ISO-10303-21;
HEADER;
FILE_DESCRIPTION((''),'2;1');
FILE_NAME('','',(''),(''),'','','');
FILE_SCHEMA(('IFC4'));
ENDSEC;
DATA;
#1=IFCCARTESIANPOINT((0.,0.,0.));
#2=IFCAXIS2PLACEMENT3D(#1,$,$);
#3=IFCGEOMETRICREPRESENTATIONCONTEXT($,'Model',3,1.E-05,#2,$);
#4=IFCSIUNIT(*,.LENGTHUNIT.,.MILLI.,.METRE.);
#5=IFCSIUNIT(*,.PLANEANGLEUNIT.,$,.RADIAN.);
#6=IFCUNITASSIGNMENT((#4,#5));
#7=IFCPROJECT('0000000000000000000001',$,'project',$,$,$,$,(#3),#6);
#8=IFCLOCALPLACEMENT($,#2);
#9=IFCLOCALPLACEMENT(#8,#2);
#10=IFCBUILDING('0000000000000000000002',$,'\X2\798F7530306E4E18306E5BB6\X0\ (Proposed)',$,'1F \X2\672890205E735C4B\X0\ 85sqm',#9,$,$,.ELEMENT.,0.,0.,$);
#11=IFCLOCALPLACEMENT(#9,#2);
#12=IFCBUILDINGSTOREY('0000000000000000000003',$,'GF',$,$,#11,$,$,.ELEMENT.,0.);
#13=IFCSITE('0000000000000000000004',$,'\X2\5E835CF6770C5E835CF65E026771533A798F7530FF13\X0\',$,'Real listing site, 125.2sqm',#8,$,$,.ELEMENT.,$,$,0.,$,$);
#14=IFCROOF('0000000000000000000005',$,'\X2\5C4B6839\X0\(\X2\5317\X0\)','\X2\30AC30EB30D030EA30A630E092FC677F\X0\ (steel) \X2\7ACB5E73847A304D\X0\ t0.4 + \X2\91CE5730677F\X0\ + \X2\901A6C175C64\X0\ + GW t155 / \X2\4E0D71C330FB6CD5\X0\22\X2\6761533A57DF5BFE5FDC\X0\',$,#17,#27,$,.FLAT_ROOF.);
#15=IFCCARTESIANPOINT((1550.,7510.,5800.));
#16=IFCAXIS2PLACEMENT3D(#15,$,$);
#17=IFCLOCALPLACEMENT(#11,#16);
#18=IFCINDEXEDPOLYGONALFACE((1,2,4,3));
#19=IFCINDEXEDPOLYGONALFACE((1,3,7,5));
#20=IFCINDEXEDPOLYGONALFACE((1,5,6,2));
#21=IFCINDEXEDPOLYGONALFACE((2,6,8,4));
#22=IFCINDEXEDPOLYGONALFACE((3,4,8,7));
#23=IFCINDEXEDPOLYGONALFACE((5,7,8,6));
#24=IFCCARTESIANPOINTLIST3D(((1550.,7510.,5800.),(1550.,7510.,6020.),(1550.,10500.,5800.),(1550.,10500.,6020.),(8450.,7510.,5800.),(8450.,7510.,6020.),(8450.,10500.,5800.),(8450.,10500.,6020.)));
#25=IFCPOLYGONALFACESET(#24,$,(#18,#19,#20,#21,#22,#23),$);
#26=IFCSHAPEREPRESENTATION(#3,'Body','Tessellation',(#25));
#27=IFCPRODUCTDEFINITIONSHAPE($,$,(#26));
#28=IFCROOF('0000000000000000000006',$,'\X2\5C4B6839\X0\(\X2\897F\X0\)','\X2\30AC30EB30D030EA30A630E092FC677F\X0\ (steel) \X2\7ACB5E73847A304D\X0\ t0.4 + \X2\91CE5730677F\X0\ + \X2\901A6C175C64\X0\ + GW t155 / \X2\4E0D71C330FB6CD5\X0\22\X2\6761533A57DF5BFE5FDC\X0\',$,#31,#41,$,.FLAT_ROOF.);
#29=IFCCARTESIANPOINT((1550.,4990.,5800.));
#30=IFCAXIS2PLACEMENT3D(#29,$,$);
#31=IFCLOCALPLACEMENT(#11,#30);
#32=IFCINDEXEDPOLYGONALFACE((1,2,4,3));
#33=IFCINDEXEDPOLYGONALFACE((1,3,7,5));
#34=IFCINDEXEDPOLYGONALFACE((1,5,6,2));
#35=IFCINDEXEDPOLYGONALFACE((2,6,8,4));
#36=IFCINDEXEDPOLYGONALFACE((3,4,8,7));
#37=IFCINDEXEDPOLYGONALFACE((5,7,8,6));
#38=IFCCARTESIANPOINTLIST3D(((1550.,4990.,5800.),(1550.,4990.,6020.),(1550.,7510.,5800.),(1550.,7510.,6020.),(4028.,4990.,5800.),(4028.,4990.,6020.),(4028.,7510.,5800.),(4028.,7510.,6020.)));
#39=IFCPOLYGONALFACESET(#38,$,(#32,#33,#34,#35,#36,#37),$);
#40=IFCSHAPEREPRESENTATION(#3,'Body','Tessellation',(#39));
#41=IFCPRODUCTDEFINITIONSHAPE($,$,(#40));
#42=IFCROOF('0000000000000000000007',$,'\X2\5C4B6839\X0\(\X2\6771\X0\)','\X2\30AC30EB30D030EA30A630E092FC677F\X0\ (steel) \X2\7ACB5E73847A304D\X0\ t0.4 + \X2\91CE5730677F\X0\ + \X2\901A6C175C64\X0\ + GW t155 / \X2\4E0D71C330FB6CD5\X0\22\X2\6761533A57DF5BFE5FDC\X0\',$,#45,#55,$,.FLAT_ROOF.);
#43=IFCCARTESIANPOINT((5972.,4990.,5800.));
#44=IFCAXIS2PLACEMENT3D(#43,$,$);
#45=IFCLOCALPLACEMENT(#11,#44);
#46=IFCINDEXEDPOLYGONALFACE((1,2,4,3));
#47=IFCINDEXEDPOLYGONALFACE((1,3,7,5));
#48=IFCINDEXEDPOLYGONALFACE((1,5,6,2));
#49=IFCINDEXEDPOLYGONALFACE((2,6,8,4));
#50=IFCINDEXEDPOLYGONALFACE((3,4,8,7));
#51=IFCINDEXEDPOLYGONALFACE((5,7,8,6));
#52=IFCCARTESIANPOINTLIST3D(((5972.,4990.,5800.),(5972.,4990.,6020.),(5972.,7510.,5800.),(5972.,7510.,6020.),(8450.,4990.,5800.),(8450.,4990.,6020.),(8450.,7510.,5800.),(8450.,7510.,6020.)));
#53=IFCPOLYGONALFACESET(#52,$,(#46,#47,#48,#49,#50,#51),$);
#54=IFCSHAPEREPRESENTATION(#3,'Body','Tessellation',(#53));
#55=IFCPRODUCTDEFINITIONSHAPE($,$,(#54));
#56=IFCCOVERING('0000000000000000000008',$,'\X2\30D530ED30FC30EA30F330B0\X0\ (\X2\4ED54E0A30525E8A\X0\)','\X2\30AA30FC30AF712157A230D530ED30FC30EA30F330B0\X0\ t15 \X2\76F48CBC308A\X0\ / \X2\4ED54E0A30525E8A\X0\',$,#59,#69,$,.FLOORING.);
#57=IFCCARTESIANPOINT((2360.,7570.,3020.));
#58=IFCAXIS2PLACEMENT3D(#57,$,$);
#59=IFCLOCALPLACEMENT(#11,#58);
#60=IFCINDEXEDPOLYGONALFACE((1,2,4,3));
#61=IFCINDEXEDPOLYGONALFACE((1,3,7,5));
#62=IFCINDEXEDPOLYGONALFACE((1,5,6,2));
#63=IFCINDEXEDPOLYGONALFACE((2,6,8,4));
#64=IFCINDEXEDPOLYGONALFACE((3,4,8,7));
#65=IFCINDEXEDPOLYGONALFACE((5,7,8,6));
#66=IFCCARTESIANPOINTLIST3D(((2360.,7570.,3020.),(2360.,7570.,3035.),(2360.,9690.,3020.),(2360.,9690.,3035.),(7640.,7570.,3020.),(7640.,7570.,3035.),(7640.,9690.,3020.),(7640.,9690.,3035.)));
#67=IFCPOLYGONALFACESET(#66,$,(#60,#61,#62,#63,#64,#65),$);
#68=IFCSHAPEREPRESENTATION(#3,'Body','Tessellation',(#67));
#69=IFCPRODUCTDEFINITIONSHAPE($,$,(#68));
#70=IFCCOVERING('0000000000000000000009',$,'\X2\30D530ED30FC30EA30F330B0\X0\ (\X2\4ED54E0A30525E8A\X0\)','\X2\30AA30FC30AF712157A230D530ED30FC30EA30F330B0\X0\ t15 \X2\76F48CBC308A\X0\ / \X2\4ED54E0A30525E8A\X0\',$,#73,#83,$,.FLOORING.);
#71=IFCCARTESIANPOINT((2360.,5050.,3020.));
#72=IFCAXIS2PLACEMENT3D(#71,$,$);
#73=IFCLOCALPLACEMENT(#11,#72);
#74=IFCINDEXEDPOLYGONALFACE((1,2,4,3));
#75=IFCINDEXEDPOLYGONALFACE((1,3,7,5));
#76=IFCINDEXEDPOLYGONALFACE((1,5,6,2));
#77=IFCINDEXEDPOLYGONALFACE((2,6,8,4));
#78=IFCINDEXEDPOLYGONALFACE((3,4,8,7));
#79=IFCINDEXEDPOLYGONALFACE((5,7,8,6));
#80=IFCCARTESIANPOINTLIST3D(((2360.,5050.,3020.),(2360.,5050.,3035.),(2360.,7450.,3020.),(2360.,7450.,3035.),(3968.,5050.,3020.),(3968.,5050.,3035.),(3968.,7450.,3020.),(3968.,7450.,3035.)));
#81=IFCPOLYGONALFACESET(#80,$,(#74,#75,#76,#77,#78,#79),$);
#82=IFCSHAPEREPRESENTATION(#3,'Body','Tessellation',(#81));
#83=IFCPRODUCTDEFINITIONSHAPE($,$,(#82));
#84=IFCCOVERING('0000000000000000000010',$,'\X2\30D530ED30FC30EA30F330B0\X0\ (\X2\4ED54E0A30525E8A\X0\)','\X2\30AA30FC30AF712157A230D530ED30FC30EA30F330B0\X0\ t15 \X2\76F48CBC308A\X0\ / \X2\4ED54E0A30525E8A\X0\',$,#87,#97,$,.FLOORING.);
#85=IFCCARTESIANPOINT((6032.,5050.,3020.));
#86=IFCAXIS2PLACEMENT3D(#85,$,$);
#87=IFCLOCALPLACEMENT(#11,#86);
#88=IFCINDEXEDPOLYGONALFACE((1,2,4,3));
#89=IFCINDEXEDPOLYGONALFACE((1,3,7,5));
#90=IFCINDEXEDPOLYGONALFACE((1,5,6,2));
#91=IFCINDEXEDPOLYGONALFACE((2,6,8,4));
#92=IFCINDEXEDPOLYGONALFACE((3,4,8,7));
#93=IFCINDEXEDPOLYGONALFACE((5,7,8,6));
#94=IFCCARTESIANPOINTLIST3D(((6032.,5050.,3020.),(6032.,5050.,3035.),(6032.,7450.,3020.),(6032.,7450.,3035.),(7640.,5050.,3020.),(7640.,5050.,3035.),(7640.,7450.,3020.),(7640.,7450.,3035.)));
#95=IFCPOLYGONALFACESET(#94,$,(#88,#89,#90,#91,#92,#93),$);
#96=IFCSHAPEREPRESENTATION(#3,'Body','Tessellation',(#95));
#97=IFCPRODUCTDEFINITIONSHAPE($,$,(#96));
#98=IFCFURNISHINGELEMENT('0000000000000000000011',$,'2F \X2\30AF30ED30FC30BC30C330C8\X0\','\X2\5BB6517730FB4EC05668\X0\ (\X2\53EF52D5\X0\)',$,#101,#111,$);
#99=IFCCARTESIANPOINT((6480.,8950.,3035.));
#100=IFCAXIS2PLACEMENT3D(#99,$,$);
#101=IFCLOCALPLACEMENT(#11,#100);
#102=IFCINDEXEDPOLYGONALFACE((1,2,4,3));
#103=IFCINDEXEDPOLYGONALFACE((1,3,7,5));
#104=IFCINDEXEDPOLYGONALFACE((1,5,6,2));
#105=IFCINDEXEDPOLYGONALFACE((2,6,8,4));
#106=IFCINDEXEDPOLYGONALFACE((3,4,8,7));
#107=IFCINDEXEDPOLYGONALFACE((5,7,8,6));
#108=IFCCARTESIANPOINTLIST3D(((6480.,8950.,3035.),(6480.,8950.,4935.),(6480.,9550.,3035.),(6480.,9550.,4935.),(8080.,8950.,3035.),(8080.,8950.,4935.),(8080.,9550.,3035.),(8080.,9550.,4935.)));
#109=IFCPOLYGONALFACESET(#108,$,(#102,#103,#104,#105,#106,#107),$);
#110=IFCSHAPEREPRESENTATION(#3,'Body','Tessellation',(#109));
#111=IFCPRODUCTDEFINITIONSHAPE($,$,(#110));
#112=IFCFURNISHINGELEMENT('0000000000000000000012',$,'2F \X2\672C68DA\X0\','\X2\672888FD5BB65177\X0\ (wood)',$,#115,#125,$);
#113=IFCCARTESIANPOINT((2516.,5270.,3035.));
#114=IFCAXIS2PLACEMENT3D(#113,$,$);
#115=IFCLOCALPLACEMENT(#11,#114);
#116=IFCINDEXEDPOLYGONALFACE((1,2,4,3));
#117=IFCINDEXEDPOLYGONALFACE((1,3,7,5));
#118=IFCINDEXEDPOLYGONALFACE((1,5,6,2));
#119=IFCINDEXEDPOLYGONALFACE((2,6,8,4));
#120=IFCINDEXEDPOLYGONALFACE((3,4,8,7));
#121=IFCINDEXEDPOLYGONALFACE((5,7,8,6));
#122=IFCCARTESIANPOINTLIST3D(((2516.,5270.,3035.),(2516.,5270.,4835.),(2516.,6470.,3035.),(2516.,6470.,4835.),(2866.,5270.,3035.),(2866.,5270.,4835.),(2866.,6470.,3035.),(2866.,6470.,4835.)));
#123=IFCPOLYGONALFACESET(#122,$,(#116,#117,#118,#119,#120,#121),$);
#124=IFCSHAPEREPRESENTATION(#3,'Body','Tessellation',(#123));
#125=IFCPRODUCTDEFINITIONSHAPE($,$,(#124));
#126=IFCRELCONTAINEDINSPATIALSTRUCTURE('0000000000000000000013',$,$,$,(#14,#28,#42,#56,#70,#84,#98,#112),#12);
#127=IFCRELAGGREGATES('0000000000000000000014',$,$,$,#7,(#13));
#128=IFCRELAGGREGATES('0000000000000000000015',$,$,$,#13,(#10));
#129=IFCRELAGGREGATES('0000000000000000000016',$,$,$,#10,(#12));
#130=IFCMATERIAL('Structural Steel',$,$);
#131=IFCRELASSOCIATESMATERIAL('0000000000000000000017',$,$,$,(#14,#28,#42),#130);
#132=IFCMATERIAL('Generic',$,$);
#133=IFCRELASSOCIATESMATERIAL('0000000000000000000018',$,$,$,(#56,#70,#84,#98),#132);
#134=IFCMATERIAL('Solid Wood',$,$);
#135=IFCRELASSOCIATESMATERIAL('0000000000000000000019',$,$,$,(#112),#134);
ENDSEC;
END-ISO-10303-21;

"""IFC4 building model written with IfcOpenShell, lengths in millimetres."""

from ifc_helpers import new_model, si_unit, frame, frame_2d, origin, place, context, project, spatial, rectangle, extrude, material, element, save


model = new_model("IFC4")

# Units and contexts
model_context = context("Model", 3, precision=1e-05, world=origin())
ifc_project = project(units=[si_unit("LENGTHUNIT", "METRE", prefix="MILLI"), si_unit("PLANEANGLEUNIT", "RADIAN")], contexts=[model_context])

# Site, building, storey
site_placement = place(None, origin())
site = spatial("IfcSite", under=ifc_project, at=site_placement, Name="広島県広島市東区福田３", ObjectType="Real listing site, 125.2sqm", CompositionType="ELEMENT", RefElevation=0.0)
building_placement = place(site_placement, origin())
building = spatial("IfcBuilding", under=site, at=building_placement, Name="福田の丘の家 (Proposed)", ObjectType="1F 木造平屋 85sqm", CompositionType="ELEMENT", ElevationOfRefHeight=0.0, ElevationOfTerrain=0.0)
storey_placement = place(building_placement, origin())
storey = spatial("IfcBuildingStorey", under=building, at=storey_placement, Name="GF", CompositionType="ELEMENT", Elevation=0.0)

# Shared definitions
ifc_material_1 = material(Name="Solid Wood")

# Shared definitions
ifc_material_2 = material(Name="Generic")

# Roofs
ifc_material_3 = material(Name="Structural Steel")
for number, where, name in (
    (1, (1550.0, 7510.0, 5800.0), "屋根(北)"),
):
    element("IfcRoof", number, at=place(storey_placement, frame(where)), inside=storey, material=ifc_material_3, Name=name, Description="ガルバリウム鋼板 (steel) 立平葺き t0.4 + 野地板 + 通気層 + GW t155 / 不燃・法22条区域対応", PredefinedType="FLAT_ROOF", context=model_context, shape_type="SweptSolid", body=[
        extrude(rectangle(XDim=6900.0, YDim=2990.0, at=frame_2d((3450.0, 1495.0))), frame((1550.0, 7510.0, 5800.0)), (0.0, 0.0, 1.0), 220.0),
    ])
roof_1_placement = place(storey_placement, frame((1550.0, 4990.0, 5800.0)))
element("IfcRoof", 2, at=roof_1_placement, inside=storey, material=ifc_material_3, Name="屋根(西)", Description="ガルバリウム鋼板 (steel) 立平葺き t0.4 + 野地板 + 通気層 + GW t155 / 不燃・法22条区域対応", PredefinedType="FLAT_ROOF", context=model_context, shape_type="SweptSolid", body=[
    extrude(rectangle(XDim=2478.0, YDim=2520.0, at=frame_2d((1239.0, 1260.0))), frame((1550.0, 4990.0, 5800.0)), (0.0, 0.0, 1.0), 220.0),
])
roof_2_placement = place(storey_placement, frame((5972.0, 4990.0, 5800.0)))
element("IfcRoof", 3, at=roof_2_placement, inside=storey, material=ifc_material_3, Name="屋根(東)", Description="ガルバリウム鋼板 (steel) 立平葺き t0.4 + 野地板 + 通気層 + GW t155 / 不燃・法22条区域対応", PredefinedType="FLAT_ROOF", context=model_context, shape_type="SweptSolid", body=[
    extrude(rectangle(XDim=2478.0, YDim=2520.0, at=frame_2d((1239.0, 1260.0))), frame((5972.0, 4990.0, 5800.0)), (0.0, 0.0, 1.0), 220.0),
])

# Coverings
covering_1_placement = place(storey_placement, frame((2360.0, 7570.0, 3020.0)))
element("IfcCovering", 4, at=covering_1_placement, inside=storey, material=ifc_material_2, Name="フローリング (仕上げ床)", Description="オーク無垢フローリング t15 直貼り / 仕上げ床", PredefinedType="FLOORING", context=model_context, shape_type="SweptSolid", body=[
    extrude(rectangle(XDim=5280.0, YDim=2120.0, at=frame_2d((2640.0, 1060.0))), frame((2360.0, 7570.0, 3020.0)), (0.0, 0.0, 1.0), 15.0),
])
covering_2_placement = place(storey_placement, frame((2360.0, 5050.0, 3020.0)))
element("IfcCovering", 5, at=covering_2_placement, inside=storey, material=ifc_material_2, Name="フローリング (仕上げ床)", Description="オーク無垢フローリング t15 直貼り / 仕上げ床", PredefinedType="FLOORING", context=model_context, shape_type="SweptSolid", body=[
    extrude(rectangle(XDim=1608.0, YDim=2400.0, at=frame_2d((804.0, 1200.0))), frame((2360.0, 5050.0, 3020.0)), (0.0, 0.0, 1.0), 15.0),
])
covering_3_placement = place(storey_placement, frame((6032.0, 5050.0, 3020.0)))
element("IfcCovering", 6, at=covering_3_placement, inside=storey, material=ifc_material_2, Name="フローリング (仕上げ床)", Description="オーク無垢フローリング t15 直貼り / 仕上げ床", PredefinedType="FLOORING", context=model_context, shape_type="SweptSolid", body=[
    extrude(rectangle(XDim=1608.0, YDim=2400.0, at=frame_2d((804.0, 1200.0))), frame((6032.0, 5050.0, 3020.0)), (0.0, 0.0, 1.0), 15.0),
])

# Furnishing elements
furnishing_1_placement = place(storey_placement, frame((6480.0, 8950.0, 3035.0)))
element("IfcFurnishingElement", 7, at=furnishing_1_placement, inside=storey, material=ifc_material_2, Name="2F クローゼット", Description="家具・什器 (可動)", context=model_context, shape_type="SweptSolid", body=[
    extrude(rectangle(XDim=1600.0, YDim=600.0, at=frame_2d((800.0, 300.0))), frame((6480.0, 8950.0, 3035.0)), (0.0, 0.0, 1.0), 1900.0),
])
furnishing_2_placement = place(storey_placement, frame((2516.0, 5270.0, 3035.0)))
element("IfcFurnishingElement", 8, at=furnishing_2_placement, inside=storey, material=ifc_material_1, Name="2F 本棚", Description="木製家具 (wood)", context=model_context, shape_type="SweptSolid", body=[
    extrude(rectangle(XDim=350.0, YDim=1200.0, at=frame_2d((175.0, 600.0))), frame((2516.0, 5270.0, 3035.0)), (0.0, 0.0, 1.0), 1800.0),
])

save(model, "model.ifc")
